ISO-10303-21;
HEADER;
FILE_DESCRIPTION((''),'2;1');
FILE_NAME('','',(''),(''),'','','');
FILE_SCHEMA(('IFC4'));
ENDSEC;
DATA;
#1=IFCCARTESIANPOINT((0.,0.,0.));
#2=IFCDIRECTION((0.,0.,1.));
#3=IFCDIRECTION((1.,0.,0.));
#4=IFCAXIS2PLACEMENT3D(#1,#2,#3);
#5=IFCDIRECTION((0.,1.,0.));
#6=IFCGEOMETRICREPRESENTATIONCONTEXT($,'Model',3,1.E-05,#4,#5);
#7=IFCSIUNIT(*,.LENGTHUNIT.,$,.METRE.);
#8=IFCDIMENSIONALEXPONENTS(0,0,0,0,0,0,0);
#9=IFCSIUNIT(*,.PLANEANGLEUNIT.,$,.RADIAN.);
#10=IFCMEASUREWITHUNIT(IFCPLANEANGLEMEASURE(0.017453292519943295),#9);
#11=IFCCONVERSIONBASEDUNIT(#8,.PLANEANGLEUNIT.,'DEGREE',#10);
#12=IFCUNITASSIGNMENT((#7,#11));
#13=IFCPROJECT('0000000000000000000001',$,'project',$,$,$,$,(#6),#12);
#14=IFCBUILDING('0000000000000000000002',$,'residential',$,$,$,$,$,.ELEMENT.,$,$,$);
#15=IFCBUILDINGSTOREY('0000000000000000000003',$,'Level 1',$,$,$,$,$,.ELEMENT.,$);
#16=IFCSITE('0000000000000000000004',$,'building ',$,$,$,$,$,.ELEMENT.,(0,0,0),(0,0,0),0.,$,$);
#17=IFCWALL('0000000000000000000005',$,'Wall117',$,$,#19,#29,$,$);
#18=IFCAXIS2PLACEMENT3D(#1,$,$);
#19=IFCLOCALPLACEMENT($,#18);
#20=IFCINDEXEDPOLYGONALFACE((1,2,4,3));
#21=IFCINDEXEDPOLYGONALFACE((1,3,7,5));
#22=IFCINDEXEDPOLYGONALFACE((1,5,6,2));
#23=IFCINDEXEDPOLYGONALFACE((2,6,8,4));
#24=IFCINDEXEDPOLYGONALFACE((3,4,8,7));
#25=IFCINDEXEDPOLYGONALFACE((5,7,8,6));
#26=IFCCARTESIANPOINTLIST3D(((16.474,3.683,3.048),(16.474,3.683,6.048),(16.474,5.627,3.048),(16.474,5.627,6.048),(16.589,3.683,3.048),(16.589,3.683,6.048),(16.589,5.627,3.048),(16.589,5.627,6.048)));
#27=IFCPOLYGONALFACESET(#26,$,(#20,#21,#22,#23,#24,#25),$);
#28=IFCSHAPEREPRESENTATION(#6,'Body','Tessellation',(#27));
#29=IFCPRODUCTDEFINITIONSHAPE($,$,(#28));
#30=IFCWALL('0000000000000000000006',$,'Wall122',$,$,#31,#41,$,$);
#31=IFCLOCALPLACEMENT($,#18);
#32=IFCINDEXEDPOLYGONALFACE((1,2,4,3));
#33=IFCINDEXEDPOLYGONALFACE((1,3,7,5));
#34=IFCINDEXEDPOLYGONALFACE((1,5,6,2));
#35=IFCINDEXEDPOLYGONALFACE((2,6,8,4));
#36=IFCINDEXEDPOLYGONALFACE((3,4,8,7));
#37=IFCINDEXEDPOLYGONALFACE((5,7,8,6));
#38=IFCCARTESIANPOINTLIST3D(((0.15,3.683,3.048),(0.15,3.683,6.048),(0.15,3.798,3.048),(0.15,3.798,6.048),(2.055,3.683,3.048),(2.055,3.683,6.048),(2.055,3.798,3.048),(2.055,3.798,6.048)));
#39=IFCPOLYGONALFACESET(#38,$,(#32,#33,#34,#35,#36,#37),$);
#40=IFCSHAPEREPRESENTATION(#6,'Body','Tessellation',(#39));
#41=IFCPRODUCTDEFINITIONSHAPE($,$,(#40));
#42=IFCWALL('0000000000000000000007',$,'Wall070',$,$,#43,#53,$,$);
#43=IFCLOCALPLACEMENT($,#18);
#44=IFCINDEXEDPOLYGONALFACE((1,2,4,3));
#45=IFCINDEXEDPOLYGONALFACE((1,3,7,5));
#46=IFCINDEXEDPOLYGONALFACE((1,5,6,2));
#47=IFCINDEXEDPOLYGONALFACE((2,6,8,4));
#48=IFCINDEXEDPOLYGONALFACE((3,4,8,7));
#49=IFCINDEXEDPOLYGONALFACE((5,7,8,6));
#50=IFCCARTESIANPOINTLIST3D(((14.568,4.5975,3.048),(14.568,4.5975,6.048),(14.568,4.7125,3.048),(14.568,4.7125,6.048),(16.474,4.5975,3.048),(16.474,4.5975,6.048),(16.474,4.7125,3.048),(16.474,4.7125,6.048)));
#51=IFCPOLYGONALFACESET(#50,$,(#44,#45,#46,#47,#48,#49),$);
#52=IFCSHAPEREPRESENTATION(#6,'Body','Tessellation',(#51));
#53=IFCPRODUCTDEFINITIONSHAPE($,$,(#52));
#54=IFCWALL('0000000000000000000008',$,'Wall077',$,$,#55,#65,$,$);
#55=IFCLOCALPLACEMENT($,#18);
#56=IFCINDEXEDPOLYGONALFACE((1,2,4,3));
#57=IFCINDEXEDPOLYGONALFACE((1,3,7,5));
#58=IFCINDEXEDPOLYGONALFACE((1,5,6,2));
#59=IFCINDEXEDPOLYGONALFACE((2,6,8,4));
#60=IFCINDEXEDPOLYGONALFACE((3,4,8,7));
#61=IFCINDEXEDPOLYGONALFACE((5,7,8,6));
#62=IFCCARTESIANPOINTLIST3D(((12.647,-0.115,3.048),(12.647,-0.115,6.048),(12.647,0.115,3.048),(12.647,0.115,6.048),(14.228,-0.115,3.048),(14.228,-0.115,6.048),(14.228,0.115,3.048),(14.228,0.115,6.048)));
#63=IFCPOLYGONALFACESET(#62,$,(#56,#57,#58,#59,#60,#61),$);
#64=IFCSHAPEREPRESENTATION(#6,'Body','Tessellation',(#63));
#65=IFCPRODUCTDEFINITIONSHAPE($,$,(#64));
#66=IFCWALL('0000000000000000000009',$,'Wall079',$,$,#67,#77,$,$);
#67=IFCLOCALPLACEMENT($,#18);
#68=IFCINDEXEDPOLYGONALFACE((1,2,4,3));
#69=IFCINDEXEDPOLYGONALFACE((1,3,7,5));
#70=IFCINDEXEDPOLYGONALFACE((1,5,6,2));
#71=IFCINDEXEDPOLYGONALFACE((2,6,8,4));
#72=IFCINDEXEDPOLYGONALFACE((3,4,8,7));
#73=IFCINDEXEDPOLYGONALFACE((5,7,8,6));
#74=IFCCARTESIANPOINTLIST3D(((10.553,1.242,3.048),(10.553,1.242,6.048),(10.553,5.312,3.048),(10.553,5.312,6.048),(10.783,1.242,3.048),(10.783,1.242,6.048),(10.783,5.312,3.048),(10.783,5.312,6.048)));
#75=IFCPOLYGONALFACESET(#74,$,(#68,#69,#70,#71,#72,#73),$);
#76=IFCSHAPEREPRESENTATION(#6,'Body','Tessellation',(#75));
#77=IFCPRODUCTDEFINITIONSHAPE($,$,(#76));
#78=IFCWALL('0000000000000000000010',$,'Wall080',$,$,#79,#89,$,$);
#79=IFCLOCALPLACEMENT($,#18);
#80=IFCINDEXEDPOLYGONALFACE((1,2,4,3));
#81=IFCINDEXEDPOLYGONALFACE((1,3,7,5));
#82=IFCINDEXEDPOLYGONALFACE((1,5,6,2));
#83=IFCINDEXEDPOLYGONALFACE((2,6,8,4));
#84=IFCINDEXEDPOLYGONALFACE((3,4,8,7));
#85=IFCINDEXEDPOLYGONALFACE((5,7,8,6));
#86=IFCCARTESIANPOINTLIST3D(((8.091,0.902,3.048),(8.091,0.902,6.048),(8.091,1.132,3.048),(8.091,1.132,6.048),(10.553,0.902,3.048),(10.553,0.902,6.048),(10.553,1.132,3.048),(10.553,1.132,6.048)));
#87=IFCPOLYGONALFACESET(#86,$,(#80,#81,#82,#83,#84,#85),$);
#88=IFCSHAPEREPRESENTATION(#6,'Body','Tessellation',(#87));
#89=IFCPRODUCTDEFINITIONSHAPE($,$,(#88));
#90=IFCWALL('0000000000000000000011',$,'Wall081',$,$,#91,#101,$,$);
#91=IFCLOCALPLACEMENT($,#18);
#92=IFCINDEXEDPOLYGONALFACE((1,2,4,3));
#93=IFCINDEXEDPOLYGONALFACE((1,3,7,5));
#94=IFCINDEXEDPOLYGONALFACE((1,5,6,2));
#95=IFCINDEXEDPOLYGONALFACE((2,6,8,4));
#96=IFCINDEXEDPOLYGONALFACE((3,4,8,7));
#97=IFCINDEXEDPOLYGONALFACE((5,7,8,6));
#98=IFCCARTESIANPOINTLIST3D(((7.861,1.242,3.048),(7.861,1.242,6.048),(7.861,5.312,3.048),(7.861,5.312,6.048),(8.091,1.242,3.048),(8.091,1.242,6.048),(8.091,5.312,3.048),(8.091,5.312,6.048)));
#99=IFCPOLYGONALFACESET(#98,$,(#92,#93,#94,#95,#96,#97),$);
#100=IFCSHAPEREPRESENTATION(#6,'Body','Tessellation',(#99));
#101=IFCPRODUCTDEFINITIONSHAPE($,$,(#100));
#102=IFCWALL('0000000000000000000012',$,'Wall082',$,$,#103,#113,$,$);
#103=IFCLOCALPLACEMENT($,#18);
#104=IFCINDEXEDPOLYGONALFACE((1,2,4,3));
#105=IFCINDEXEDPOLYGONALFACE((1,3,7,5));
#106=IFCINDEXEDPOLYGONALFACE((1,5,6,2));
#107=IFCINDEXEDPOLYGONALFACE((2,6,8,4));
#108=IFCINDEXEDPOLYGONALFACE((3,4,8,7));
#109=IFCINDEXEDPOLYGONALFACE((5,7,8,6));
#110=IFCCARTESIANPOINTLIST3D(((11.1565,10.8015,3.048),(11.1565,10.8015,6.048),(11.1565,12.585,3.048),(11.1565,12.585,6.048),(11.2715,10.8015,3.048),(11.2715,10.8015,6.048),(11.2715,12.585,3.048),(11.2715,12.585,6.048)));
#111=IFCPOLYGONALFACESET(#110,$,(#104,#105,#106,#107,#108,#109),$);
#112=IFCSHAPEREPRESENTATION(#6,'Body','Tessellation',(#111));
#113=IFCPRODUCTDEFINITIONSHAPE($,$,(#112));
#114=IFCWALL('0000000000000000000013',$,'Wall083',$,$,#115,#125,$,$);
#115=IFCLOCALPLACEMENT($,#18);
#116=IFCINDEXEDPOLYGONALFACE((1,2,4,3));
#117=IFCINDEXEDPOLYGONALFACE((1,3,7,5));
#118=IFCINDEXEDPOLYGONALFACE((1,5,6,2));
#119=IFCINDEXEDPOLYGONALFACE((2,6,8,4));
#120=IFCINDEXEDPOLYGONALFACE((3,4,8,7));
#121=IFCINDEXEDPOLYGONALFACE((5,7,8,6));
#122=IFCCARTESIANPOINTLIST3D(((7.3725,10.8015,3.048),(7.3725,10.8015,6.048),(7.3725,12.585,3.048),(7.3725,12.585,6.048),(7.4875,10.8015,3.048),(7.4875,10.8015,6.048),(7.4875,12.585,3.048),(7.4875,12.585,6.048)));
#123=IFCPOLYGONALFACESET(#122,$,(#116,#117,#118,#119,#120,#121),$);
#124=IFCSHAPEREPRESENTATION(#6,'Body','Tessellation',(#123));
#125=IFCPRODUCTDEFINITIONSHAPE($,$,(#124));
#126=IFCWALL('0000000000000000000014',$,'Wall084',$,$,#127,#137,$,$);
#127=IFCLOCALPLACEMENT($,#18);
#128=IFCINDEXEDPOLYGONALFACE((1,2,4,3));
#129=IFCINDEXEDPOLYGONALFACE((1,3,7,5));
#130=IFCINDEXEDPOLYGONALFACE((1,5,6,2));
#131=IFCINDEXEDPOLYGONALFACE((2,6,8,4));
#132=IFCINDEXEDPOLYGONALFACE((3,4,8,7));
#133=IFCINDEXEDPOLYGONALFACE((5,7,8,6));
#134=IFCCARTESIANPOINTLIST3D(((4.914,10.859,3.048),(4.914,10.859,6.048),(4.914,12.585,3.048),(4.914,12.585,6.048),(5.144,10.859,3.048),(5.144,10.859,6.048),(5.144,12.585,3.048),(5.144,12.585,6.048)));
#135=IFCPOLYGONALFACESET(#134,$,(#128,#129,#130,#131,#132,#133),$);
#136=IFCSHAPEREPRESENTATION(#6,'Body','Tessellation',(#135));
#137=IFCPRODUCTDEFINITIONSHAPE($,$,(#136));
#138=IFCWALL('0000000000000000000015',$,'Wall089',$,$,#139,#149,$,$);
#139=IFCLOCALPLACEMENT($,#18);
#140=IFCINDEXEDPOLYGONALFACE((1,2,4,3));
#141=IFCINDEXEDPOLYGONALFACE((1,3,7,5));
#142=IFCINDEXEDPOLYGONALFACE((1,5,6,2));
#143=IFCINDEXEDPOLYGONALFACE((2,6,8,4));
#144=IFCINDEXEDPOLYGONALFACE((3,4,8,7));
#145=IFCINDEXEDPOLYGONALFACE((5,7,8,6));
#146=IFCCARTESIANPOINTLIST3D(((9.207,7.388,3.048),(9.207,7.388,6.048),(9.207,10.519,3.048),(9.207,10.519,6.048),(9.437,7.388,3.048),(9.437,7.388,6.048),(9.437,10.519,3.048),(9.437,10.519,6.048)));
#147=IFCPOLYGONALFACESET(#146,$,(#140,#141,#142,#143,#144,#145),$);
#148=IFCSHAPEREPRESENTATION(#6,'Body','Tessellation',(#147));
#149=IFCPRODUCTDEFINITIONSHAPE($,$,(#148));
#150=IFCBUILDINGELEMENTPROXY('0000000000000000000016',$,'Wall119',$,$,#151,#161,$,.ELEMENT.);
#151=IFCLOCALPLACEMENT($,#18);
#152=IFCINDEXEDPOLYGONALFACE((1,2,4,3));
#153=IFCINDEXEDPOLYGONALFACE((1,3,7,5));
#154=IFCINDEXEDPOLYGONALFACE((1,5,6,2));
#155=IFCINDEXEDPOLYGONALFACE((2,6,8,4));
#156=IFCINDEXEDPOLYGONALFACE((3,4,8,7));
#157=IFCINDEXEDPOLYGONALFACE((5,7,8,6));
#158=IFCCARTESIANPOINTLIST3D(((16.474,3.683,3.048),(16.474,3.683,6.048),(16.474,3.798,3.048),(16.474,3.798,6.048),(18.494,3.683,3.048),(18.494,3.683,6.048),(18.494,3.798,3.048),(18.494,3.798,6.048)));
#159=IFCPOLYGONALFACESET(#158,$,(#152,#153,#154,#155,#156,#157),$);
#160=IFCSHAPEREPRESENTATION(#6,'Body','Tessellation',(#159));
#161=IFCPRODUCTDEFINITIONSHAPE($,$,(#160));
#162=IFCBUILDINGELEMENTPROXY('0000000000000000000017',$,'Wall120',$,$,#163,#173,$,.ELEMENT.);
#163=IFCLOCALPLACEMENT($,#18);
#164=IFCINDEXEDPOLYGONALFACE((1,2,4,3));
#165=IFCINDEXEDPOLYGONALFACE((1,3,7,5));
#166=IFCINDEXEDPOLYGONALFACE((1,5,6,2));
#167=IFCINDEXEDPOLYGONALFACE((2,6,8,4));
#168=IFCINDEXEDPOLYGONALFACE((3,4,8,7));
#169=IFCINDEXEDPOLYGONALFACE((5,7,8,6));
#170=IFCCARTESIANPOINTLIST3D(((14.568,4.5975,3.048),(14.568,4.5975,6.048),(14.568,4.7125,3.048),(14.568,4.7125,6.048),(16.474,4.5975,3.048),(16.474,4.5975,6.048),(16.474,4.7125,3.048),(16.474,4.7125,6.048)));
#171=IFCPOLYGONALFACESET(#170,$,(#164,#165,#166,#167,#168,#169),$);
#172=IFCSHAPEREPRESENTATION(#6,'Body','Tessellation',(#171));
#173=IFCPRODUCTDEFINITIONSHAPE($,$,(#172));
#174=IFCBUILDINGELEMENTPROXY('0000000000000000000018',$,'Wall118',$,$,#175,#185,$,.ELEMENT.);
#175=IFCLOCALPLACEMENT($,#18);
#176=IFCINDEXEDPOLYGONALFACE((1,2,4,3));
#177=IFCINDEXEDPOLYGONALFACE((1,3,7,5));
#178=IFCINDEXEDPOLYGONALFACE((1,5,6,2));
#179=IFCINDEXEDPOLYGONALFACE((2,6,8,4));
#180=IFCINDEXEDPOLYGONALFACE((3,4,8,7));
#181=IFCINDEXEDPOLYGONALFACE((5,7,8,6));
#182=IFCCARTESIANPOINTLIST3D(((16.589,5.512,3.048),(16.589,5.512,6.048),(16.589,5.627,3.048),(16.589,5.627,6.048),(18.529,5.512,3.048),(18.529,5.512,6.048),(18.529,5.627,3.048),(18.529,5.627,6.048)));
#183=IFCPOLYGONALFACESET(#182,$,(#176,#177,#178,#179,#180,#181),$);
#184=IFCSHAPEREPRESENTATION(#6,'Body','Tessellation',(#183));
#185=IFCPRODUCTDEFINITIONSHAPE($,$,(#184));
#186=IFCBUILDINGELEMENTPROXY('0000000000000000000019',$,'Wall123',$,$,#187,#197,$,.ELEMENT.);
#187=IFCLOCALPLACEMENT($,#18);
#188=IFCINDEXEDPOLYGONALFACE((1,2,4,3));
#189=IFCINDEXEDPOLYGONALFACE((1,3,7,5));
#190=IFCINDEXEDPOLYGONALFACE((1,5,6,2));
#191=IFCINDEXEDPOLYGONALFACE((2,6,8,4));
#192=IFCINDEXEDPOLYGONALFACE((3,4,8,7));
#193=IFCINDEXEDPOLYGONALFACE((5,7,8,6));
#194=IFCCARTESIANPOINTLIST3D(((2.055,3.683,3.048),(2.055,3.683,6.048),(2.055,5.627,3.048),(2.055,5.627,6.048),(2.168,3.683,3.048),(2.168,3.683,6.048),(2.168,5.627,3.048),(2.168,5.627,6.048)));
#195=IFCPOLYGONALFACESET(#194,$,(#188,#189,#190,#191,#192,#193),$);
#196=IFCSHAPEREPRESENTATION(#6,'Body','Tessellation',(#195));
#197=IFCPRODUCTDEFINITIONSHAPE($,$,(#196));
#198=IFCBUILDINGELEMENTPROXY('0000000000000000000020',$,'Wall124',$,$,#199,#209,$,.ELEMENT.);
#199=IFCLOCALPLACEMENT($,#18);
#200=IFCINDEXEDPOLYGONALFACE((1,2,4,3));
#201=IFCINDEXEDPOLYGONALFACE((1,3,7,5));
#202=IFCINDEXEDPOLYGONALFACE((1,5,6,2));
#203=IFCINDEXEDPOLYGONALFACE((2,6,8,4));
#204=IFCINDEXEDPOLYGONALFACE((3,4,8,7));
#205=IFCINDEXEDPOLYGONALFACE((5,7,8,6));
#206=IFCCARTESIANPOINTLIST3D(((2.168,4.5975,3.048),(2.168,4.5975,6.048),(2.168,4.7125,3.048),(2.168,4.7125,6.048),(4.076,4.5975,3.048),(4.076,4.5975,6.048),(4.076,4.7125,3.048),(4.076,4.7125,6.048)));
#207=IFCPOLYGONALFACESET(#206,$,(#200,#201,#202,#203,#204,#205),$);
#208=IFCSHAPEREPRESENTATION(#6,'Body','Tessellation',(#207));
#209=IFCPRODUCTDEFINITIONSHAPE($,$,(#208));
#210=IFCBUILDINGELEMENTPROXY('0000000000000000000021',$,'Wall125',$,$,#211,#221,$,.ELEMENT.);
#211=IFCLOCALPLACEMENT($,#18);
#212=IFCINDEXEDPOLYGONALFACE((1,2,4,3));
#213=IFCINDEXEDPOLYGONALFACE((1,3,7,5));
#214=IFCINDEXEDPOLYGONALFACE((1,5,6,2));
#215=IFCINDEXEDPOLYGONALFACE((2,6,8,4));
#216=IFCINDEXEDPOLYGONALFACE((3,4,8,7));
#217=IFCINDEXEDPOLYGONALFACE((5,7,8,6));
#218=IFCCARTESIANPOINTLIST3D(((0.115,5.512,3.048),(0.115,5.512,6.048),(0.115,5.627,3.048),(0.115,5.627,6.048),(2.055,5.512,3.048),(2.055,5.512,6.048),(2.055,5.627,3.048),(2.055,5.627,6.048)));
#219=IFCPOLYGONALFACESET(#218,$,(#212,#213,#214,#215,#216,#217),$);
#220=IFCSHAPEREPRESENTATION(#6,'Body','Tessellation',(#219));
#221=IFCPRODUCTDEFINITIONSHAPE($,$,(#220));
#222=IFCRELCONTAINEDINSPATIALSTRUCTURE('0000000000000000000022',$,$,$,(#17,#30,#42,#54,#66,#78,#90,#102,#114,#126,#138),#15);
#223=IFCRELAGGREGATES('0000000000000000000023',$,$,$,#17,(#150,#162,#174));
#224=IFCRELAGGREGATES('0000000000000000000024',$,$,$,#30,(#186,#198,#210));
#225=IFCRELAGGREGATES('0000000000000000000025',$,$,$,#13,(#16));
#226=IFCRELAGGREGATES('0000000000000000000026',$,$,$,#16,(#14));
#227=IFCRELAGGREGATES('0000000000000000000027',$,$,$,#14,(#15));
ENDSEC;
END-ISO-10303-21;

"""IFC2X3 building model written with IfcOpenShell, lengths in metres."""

from ifc_helpers import new_model, entity, si_unit, converted_unit, direction, frame, frame_2d, origin_with_axes, place, context, project, spatial, rectangle, extrude, element, aggregate, save


model = new_model("IFC2X3")

# Units and contexts
model_context = context("Model", 3, precision=1e-05, world=origin_with_axes(), true_north=direction((0.0, 1.0, 0.0)))
ifc_project = project(units=[si_unit("LENGTHUNIT", "METRE"), converted_unit("PLANEANGLEUNIT", "DEGREE", entity("IfcPlaneAngleMeasure", 0.017453292519943295), si_unit("PLANEANGLEUNIT", "RADIAN"), dimensions=[0, 0, 0, 0, 0, 0, 0])], contexts=[model_context])

# Site, building, storey
site = spatial("IfcSite", under=ifc_project, Name="building ", CompositionType="ELEMENT", RefLatitude=(0, 0, 0), RefLongitude=(0, 0, 0), RefElevation=0.0)
building = spatial("IfcBuilding", under=site, Name="residential", CompositionType="ELEMENT")
storey = spatial("IfcBuildingStorey", under=building, Name="Level 1", CompositionType="ELEMENT")

# Shared definitions
placement = place(None, origin_with_axes())

# Walls
wall_1 = element("IfcWall", 1, at=placement, inside=storey, Name="Wall117", context=model_context, shape_type="SweptSolid", body=[
    extrude(rectangle(XDim=1.944, YDim=0.115, at=frame_2d((0.0, 0.0), x_axis=(0.0, 1.0, 0.0))), frame((16.5315, 4.655, 3.048), z_axis=(0.0, 0.0, 1.0), x_axis=(1.0, 0.0, 0.0)), (0.0, 0.0, 1.0), 3.0),
])
wall_2 = element("IfcWall", 2, at=placement, inside=storey, Name="Wall122", context=model_context, shape_type="SweptSolid", body=[
    extrude(rectangle(XDim=1.905, YDim=0.115, at=frame_2d((0.0, 0.0), x_axis=(1.0, 0.0, 0.0))), frame((1.1025, 3.7405, 3.048), z_axis=(0.0, 0.0, 1.0), x_axis=(1.0, 0.0, 0.0)), (0.0, 0.0, 1.0), 3.0),
])

# Walls
element("IfcWall", 3, at=placement, inside=storey, Name="Wall070", context=model_context, shape_type="SweptSolid", body=[
    extrude(rectangle(XDim=1.906, YDim=0.115, at=frame_2d((0.0, 0.0), x_axis=(-1.0, 0.0, 0.0))), frame((15.521, 4.655, 3.048), z_axis=(0.0, 0.0, 1.0), x_axis=(1.0, 0.0, 0.0)), (0.0, 0.0, 1.0), 3.0),
])
element("IfcWall", 4, at=placement, inside=storey, Name="Wall077", context=model_context, shape_type="SweptSolid", body=[
    extrude(rectangle(XDim=1.581, YDim=0.23, at=frame_2d((0.0, 0.0), x_axis=(-1.0, 0.0, 0.0))), frame((13.4375, 0.0, 3.048), z_axis=(0.0, 0.0, 1.0), x_axis=(1.0, 0.0, 0.0)), (0.0, 0.0, 1.0), 3.0),
])
element("IfcWall", 5, at=placement, inside=storey, Name="Wall079", context=model_context, shape_type="SweptSolid", body=[
    extrude(rectangle(XDim=4.07, YDim=0.23, at=frame_2d((0.0, 0.0), x_axis=(0.0, -1.0, 0.0))), frame((10.668, 3.277, 3.048), z_axis=(0.0, 0.0, 1.0), x_axis=(1.0, 0.0, 0.0)), (0.0, 0.0, 1.0), 3.0),
])
element("IfcWall", 6, at=placement, inside=storey, Name="Wall080", context=model_context, shape_type="SweptSolid", body=[
    extrude(rectangle(XDim=2.462, YDim=0.23, at=frame_2d((0.0, 0.0), x_axis=(1.0, 0.0, 0.0))), frame((9.322, 1.017, 3.048), z_axis=(0.0, 0.0, 1.0), x_axis=(1.0, 0.0, 0.0)), (0.0, 0.0, 1.0), 3.0),
])
element("IfcWall", 7, at=placement, inside=storey, Name="Wall081", context=model_context, shape_type="SweptSolid", body=[
    extrude(rectangle(XDim=4.07, YDim=0.23, at=frame_2d((0.0, 0.0), x_axis=(0.0, -1.0, 0.0))), frame((7.976, 3.277, 3.048), z_axis=(0.0, 0.0, 1.0), x_axis=(1.0, 0.0, 0.0)), (0.0, 0.0, 1.0), 3.0),
])
element("IfcWall", 8, at=placement, inside=storey, Name="Wall082", context=model_context, shape_type="SweptSolid", body=[
    extrude(rectangle(XDim=1.7835, YDim=0.115, at=frame_2d((0.0, 0.0), x_axis=(0.0, -1.0, 0.0))), frame((11.214, 11.6933, 3.048), z_axis=(0.0, 0.0, 1.0), x_axis=(1.0, 0.0, 0.0)), (0.0, 0.0, 1.0), 3.0),
])
element("IfcWall", 9, at=placement, inside=storey, Name="Wall083", context=model_context, shape_type="SweptSolid", body=[
    extrude(rectangle(XDim=1.7835, YDim=0.115, at=frame_2d((0.0, 0.0), x_axis=(0.0, -1.0, 0.0))), frame((7.43, 11.6933, 3.048), z_axis=(0.0, 0.0, 1.0), x_axis=(1.0, 0.0, 0.0)), (0.0, 0.0, 1.0), 3.0),
])
element("IfcWall", 10, at=placement, inside=storey, Name="Wall084", context=model_context, shape_type="SweptSolid", body=[
    extrude(rectangle(XDim=1.726, YDim=0.23, at=frame_2d((0.0, 0.0), x_axis=(0.0, 1.0, 0.0))), frame((5.029, 11.722, 3.048), z_axis=(0.0, 0.0, 1.0), x_axis=(1.0, 0.0, 0.0)), (0.0, 0.0, 1.0), 3.0),
])
element("IfcWall", 11, at=placement, inside=storey, Name="Wall089", context=model_context, shape_type="SweptSolid", body=[
    extrude(rectangle(XDim=3.131, YDim=0.23, at=frame_2d((0.0, 0.0), x_axis=(0.0, -1.0, 0.0))), frame((9.322, 8.9535, 3.048), z_axis=(0.0, 0.0, 1.0), x_axis=(1.0, 0.0, 0.0)), (0.0, 0.0, 1.0), 3.0),
])

# Building element proxies
proxy_1 = element("IfcBuildingElementProxy", 12, at=placement, Name="Wall119", CompositionType="ELEMENT", context=model_context, shape_type="SweptSolid", body=[
    extrude(rectangle(XDim=2.02, YDim=0.115, at=frame_2d((0.0, 0.0), x_axis=(1.0, 0.0, 0.0))), frame((17.484, 3.7405, 3.048), z_axis=(0.0, 0.0, 1.0), x_axis=(1.0, 0.0, 0.0)), (0.0, 0.0, 1.0), 3.0),
])
proxy_2 = element("IfcBuildingElementProxy", 13, at=placement, Name="Wall120", CompositionType="ELEMENT", context=model_context, shape_type="SweptSolid", body=[
    extrude(rectangle(XDim=1.906, YDim=0.115, at=frame_2d((0.0, 0.0), x_axis=(-1.0, 0.0, 0.0))), frame((15.521, 4.655, 3.048), z_axis=(0.0, 0.0, 1.0), x_axis=(1.0, 0.0, 0.0)), (0.0, 0.0, 1.0), 3.0),
])
proxy_3 = element("IfcBuildingElementProxy", 14, at=placement, Name="Wall118", CompositionType="ELEMENT", context=model_context, shape_type="SweptSolid", body=[
    extrude(rectangle(XDim=1.94, YDim=0.115, at=frame_2d((0.0, 0.0), x_axis=(1.0, 0.0, 0.0))), frame((17.559, 5.5695, 3.048), z_axis=(0.0, 0.0, 1.0), x_axis=(1.0, 0.0, 0.0)), (0.0, 0.0, 1.0), 3.0),
])
aggregate(wall_1, [proxy_1, proxy_2, proxy_3])
proxy_4 = element("IfcBuildingElementProxy", 15, at=placement, Name="Wall123", CompositionType="ELEMENT", context=model_context, shape_type="SweptSolid", body=[
    extrude(rectangle(XDim=1.944, YDim=0.113, at=frame_2d((0.0, 0.0), x_axis=(0.0, 1.0, 0.0))), frame((2.1115, 4.655, 3.048), z_axis=(0.0, 0.0, 1.0), x_axis=(1.0, 0.0, 0.0)), (0.0, 0.0, 1.0), 3.0),
])
proxy_5 = element("IfcBuildingElementProxy", 16, at=placement, Name="Wall124", CompositionType="ELEMENT", context=model_context, shape_type="SweptSolid", body=[
    extrude(rectangle(XDim=1.908, YDim=0.115, at=frame_2d((0.0, 0.0), x_axis=(1.0, 0.0, 0.0))), frame((3.122, 4.655, 3.048), z_axis=(0.0, 0.0, 1.0), x_axis=(1.0, 0.0, 0.0)), (0.0, 0.0, 1.0), 3.0),
])
proxy_6 = element("IfcBuildingElementProxy", 17, at=placement, Name="Wall125", CompositionType="ELEMENT", context=model_context, shape_type="SweptSolid", body=[
    extrude(rectangle(XDim=1.94, YDim=0.115, at=frame_2d((0.0, 0.0), x_axis=(-1.0, 0.0, 0.0))), frame((1.085, 5.5695, 3.048), z_axis=(0.0, 0.0, 1.0), x_axis=(1.0, 0.0, 0.0)), (0.0, 0.0, 1.0), 3.0),
])
aggregate(wall_2, [proxy_4, proxy_5, proxy_6])

save(model, "model.ifc")
